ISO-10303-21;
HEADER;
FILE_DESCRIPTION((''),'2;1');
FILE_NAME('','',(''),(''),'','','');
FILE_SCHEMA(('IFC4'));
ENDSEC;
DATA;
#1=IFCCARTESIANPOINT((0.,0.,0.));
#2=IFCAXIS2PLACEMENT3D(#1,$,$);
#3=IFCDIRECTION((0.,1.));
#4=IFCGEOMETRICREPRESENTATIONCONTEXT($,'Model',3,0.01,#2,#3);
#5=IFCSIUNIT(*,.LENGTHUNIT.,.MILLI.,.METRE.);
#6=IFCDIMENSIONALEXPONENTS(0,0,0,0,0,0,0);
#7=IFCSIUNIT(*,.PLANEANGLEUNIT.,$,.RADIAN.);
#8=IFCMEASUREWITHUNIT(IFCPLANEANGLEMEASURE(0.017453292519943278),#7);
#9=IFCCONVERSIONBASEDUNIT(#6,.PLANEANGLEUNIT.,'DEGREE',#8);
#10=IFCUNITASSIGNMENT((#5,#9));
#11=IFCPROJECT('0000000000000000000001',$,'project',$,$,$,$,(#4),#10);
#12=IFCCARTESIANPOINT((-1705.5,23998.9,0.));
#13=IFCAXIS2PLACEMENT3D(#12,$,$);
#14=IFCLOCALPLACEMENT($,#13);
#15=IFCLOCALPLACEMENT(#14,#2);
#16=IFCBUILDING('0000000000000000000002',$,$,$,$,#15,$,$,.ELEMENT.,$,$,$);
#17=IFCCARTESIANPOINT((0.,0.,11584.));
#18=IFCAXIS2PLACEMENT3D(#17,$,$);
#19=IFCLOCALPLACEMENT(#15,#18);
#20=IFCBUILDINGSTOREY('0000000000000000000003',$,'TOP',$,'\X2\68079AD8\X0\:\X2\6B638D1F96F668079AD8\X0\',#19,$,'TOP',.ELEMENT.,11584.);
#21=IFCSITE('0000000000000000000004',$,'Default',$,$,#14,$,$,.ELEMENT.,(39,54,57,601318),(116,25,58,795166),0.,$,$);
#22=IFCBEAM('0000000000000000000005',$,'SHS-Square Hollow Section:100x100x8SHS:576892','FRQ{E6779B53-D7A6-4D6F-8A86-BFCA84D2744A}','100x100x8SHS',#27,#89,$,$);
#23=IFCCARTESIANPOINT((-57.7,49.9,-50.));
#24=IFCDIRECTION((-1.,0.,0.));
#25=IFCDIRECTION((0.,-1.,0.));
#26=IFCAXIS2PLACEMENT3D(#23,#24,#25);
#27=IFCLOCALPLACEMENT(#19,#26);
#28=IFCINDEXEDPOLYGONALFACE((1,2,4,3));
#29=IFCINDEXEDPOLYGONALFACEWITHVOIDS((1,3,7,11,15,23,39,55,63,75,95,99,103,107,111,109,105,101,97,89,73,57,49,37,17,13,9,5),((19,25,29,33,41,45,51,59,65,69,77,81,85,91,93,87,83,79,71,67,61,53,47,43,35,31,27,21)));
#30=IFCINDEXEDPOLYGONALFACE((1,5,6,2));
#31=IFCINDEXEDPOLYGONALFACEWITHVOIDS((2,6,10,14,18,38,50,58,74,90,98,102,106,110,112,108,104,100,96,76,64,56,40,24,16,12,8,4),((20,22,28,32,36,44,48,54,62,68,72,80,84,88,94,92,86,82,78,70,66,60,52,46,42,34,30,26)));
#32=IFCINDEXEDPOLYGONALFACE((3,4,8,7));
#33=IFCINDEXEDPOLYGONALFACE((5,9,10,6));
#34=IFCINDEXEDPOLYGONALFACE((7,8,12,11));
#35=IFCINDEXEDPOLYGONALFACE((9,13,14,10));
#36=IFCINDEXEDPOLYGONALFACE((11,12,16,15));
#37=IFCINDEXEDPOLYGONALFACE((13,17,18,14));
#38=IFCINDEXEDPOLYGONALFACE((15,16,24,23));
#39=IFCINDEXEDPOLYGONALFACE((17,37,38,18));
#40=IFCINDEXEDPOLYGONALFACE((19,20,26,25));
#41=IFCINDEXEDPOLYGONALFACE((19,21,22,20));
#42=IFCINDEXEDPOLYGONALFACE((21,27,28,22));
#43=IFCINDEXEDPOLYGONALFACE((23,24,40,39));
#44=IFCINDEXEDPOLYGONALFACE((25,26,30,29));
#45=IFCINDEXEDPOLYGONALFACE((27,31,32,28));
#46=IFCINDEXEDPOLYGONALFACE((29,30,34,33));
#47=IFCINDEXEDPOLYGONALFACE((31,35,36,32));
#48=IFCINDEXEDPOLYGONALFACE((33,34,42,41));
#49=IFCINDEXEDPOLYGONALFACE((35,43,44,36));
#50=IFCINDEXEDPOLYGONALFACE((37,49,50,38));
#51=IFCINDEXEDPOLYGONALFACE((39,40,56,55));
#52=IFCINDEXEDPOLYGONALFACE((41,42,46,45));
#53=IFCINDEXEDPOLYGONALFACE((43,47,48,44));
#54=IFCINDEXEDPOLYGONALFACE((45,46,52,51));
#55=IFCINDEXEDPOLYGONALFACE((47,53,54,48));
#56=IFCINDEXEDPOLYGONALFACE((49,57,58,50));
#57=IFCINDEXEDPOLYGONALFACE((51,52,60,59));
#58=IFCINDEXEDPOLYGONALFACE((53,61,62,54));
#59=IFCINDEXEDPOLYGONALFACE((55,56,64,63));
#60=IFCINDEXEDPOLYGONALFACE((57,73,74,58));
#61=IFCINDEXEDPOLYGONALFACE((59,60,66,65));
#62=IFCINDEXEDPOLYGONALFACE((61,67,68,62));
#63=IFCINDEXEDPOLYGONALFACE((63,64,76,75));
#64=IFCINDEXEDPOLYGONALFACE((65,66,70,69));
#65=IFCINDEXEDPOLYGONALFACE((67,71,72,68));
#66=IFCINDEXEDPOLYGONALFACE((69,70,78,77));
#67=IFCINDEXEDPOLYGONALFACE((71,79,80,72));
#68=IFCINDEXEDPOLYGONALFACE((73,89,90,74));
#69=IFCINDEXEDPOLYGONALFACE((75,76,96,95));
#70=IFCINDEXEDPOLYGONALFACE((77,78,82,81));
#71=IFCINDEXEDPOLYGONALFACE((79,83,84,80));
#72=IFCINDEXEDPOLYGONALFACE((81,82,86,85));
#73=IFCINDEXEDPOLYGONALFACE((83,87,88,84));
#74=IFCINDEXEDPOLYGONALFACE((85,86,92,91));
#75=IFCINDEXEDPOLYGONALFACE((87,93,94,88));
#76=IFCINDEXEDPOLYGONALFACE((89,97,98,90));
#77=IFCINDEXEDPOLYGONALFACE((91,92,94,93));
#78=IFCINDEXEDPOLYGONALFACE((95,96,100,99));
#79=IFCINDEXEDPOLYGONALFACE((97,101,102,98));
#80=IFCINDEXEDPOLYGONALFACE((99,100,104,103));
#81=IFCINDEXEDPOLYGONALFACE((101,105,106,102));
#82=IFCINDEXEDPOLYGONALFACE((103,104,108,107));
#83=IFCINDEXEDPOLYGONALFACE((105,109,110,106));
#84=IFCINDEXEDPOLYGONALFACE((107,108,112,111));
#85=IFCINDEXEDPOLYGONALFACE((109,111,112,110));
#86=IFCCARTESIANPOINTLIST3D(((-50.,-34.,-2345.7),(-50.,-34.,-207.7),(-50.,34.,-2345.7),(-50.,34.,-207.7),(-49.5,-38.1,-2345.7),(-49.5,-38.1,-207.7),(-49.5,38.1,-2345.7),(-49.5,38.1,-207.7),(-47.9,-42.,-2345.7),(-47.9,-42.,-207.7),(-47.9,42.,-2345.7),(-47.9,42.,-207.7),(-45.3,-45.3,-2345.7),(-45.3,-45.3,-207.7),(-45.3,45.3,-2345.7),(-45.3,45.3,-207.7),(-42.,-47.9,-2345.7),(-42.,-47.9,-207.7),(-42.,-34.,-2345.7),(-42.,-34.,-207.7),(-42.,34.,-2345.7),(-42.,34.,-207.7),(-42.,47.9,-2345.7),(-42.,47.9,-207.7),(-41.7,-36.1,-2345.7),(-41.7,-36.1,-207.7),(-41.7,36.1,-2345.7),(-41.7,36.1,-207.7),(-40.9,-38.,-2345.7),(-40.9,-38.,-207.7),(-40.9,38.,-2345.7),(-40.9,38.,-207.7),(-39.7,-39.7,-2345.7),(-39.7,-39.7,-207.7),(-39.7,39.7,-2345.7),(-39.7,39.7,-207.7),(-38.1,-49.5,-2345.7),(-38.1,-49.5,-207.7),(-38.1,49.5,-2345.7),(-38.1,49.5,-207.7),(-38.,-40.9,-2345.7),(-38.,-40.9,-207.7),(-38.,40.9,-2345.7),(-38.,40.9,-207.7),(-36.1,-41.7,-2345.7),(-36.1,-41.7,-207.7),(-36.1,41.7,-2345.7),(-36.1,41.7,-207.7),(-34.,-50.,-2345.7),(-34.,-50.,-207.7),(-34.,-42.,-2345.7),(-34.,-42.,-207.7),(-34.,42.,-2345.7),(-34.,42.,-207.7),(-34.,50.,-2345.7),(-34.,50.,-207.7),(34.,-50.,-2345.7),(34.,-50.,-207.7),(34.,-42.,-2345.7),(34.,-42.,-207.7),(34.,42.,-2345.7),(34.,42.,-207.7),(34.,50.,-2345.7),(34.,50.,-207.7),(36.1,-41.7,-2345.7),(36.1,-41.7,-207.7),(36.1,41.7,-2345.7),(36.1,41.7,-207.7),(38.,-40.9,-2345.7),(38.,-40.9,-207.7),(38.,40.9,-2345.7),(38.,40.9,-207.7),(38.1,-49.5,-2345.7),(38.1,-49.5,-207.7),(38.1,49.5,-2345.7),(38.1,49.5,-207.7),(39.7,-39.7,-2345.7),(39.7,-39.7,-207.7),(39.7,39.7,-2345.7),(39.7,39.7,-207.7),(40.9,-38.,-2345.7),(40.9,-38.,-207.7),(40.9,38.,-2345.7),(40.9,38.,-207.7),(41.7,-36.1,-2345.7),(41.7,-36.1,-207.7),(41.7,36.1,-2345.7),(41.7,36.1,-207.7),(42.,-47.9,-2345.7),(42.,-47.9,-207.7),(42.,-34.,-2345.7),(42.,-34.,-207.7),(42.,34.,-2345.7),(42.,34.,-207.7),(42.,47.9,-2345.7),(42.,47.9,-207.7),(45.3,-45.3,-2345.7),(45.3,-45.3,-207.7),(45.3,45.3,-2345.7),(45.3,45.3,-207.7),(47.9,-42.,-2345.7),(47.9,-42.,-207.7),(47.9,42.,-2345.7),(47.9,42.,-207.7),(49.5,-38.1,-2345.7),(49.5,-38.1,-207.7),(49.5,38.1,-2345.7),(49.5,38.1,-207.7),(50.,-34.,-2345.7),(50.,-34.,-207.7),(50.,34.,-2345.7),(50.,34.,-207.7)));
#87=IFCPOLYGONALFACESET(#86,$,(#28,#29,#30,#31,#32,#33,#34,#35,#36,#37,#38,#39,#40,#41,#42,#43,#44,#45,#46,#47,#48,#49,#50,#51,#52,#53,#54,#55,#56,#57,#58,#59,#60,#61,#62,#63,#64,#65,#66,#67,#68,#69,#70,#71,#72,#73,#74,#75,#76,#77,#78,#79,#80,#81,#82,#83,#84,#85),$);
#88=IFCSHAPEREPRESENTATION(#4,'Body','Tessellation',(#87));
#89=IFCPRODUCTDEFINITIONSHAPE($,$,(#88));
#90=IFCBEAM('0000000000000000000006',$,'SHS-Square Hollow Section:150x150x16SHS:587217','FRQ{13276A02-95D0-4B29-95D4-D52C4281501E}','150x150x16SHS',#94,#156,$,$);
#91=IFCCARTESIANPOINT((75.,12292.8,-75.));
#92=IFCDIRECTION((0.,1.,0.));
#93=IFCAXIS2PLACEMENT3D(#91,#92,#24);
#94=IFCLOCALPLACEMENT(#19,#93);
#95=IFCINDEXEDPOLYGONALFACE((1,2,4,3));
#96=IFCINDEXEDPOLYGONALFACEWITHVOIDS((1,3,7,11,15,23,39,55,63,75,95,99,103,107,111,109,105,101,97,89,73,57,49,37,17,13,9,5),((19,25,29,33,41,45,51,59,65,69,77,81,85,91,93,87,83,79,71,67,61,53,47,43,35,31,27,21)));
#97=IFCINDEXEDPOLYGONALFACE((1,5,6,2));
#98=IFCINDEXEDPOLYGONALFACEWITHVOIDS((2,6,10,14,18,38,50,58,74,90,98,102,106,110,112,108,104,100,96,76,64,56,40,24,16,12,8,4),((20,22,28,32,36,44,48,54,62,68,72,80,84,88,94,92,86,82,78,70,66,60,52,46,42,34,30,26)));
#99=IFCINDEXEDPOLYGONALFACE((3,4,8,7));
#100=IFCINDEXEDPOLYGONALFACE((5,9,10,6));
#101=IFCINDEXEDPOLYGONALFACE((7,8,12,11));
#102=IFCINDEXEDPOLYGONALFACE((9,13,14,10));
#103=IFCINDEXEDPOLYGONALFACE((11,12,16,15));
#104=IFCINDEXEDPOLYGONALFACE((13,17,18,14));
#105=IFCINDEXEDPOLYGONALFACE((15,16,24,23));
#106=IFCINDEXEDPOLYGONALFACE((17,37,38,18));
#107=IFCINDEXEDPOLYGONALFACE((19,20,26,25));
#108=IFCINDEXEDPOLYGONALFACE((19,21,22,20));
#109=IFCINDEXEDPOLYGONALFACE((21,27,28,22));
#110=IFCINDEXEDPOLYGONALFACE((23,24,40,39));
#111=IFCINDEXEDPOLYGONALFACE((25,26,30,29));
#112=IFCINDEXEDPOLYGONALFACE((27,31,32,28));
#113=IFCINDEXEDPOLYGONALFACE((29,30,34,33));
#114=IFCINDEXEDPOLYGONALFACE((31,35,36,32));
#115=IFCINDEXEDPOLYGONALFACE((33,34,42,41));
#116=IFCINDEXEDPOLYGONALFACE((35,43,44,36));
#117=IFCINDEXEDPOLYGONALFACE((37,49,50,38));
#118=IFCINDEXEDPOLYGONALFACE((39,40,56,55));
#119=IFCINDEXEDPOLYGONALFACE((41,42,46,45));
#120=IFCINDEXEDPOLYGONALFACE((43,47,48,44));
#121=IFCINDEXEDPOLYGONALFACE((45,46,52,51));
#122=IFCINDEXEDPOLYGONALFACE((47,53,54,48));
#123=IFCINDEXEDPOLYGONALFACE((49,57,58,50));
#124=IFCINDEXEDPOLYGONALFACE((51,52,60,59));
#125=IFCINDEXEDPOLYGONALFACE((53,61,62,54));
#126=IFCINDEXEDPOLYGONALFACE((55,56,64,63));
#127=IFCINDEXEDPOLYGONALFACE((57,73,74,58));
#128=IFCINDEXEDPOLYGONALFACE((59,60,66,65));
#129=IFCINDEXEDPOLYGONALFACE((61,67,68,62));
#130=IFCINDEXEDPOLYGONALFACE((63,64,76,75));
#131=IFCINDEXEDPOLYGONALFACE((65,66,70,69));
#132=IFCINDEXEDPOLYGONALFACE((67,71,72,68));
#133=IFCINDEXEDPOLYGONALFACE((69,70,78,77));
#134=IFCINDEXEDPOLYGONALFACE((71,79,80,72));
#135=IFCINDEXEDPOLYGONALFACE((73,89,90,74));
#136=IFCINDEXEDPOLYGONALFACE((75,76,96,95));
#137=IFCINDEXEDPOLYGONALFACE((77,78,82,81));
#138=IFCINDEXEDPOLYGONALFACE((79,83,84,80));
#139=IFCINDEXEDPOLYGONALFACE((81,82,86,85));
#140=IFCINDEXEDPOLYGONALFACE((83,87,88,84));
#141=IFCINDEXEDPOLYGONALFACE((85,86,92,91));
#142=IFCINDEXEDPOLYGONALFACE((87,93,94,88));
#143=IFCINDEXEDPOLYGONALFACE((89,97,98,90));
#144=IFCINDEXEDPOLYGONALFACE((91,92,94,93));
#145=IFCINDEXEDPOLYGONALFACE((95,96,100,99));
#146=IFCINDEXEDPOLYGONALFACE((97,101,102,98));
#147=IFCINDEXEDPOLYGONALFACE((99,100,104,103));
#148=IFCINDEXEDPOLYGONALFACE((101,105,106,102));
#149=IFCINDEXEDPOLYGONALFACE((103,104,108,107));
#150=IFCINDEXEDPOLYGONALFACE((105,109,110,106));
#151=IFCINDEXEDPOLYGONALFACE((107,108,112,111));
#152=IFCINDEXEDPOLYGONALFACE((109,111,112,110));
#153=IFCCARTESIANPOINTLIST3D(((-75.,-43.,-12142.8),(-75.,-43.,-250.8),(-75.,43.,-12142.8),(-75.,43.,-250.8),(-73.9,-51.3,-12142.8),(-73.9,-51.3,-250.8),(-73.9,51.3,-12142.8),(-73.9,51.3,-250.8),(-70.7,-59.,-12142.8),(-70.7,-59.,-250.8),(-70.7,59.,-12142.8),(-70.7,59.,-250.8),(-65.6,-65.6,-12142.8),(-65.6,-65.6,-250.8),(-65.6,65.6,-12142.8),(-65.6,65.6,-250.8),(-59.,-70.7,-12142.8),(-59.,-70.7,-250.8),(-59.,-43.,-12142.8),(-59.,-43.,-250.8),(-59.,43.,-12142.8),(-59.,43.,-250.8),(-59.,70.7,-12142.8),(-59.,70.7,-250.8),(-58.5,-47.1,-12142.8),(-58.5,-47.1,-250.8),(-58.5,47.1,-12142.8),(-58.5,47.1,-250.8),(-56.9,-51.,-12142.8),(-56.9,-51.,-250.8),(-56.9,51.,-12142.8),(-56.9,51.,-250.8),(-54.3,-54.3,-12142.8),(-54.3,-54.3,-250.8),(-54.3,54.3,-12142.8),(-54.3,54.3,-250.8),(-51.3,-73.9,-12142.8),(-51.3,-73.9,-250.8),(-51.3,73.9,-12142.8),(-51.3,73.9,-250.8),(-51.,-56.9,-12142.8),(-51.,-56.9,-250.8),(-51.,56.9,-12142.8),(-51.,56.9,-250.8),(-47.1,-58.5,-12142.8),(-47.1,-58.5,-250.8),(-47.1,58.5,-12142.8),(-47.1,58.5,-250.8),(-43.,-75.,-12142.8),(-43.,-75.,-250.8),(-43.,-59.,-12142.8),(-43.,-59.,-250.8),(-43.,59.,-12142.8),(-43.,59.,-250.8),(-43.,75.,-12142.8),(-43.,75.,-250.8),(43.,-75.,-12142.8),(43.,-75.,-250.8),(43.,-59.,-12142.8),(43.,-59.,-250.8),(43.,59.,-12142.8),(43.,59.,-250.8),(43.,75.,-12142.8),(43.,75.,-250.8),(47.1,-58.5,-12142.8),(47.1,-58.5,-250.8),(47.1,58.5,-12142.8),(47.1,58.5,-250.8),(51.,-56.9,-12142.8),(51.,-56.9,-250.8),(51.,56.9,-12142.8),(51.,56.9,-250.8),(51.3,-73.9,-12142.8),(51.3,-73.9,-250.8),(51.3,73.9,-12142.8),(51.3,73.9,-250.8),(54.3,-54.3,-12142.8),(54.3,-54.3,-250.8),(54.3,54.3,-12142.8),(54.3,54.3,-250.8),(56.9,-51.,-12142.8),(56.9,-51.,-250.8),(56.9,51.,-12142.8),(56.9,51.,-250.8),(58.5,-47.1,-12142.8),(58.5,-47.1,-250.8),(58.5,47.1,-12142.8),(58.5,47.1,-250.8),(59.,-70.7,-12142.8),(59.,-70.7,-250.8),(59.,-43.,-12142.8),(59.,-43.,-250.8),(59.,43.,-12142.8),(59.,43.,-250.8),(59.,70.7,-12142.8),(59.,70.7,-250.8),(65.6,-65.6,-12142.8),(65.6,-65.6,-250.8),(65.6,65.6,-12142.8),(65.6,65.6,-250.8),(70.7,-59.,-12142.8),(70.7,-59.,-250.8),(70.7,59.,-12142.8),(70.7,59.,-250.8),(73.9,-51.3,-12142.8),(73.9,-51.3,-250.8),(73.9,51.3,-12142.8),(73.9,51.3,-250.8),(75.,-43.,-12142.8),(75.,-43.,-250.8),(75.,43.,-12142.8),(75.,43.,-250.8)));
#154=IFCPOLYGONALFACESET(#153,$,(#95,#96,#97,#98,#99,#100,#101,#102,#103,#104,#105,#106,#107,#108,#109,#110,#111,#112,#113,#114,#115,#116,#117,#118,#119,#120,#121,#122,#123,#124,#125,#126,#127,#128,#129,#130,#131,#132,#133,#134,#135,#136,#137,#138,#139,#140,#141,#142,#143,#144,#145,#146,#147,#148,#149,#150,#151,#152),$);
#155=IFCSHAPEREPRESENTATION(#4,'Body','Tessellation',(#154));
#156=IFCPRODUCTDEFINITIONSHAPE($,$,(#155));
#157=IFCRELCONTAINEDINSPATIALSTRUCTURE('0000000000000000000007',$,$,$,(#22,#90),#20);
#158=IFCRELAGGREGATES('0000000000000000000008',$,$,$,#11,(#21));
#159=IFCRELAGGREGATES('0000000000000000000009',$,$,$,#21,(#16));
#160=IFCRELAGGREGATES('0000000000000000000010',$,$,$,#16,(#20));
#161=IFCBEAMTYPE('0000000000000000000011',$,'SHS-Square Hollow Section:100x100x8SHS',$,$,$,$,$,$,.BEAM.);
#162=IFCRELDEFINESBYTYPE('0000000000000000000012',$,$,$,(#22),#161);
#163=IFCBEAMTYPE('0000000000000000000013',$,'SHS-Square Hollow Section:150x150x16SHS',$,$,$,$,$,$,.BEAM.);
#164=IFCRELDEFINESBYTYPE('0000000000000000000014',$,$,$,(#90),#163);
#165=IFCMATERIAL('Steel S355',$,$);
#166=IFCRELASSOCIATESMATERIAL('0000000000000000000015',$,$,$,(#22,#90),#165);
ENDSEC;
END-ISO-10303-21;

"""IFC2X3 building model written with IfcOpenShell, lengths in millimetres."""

from ifc_helpers import new_model, entity, si_unit, converted_unit, direction, frame, origin, origin_2d, place, context, project, spatial, hollow_rectangle, extrude, clip, halfspace, material, type_object, element, save


model = new_model("IFC2X3")

# Units and contexts
model_context = context("Model", 3, precision=0.01, world=origin(), true_north=direction((0.0, 1.0)))
ifc_project = project(units=[si_unit("LENGTHUNIT", "METRE", prefix="MILLI"), converted_unit("PLANEANGLEUNIT", "DEGREE", entity("IfcPlaneAngleMeasure", 0.017453292519943278), si_unit("PLANEANGLEUNIT", "RADIAN"), dimensions=[0, 0, 0, 0, 0, 0, 0])], contexts=[model_context])

# Site, building, storey
site_placement = place(None, frame((-1705.5, 23998.9, 0.0)))
site = spatial("IfcSite", under=ifc_project, at=site_placement, Name="Default", CompositionType="ELEMENT", RefLatitude=(39, 54, 57, 601318), RefLongitude=(116, 25, 58, 795166), RefElevation=0.0)
building_placement = place(site_placement, origin())
building = spatial("IfcBuilding", under=site, at=building_placement, CompositionType="ELEMENT")
storey_placement = place(building_placement, frame((0.0, 0.0, 11584.0)))
storey = spatial("IfcBuildingStorey", under=building, at=storey_placement, Name="TOP", ObjectType="标高:正负零标高", LongName="TOP", CompositionType="ELEMENT", Elevation=11584.0)

# Shared definitions
ifc_material_1 = material(Name="Steel S355")

# Beams
beam_type_1 = type_object("IfcBeamType", Name="SHS-Square Hollow Section:100x100x8SHS", PredefinedType="BEAM")
beam_1_placement = place(storey_placement, frame((-57.7, 49.9, -50.0), z_axis=(-1.0, 0.0, 0.0), x_axis=(0.0, -1.0, 0.0)))
element("IfcBeam", 1, at=beam_1_placement, inside=storey, type_object=beam_type_1, material=ifc_material_1, Name="SHS-Square Hollow Section:100x100x8SHS:576892", Description="FRQ{E6779B53-D7A6-4D6F-8A86-BFCA84D2744A}", ObjectType="100x100x8SHS", context=model_context, shape_type="Clipping", body=[
    clip(clip(extrude(hollow_rectangle(XDim=100.0, YDim=100.0, WallThickness=8.0, InnerFilletRadius=8.0, OuterFilletRadius=16.0, at=origin_2d()), origin(), (0.0, 0.0, -1.0), 2551.4), halfspace(frame((49.9, -11534.0, -207.7), z_axis=(0.0, 0.0, -1.0), x_axis=(-1.0, 0.0, 0.0)), True)), halfspace(frame((49.9, -11534.0, -2345.7), z_axis=(0.0, 0.0, 1.0), x_axis=(1.0, 0.0, 0.0)), True)),
])
beam_type_2 = type_object("IfcBeamType", Name="SHS-Square Hollow Section:150x150x16SHS", PredefinedType="BEAM")
beam_2_placement = place(storey_placement, frame((75.0, 12292.8, -75.0), z_axis=(0.0, 1.0, 0.0), x_axis=(-1.0, 0.0, 0.0)))
element("IfcBeam", 2, at=beam_2_placement, inside=storey, type_object=beam_type_2, material=ifc_material_1, Name="SHS-Square Hollow Section:150x150x16SHS:587217", Description="FRQ{13276A02-95D0-4B29-95D4-D52C4281501E}", ObjectType="150x150x16SHS", context=model_context, shape_type="Clipping", body=[
    clip(clip(extrude(hollow_rectangle(XDim=150.0, YDim=150.0, WallThickness=16.0, InnerFilletRadius=16.0, OuterFilletRadius=32.0, at=origin_2d()), origin(), (0.0, 0.0, -1.0), 12398.9), halfspace(frame((75.0, -11509.0, -12142.8), z_axis=(0.0, 0.0, 1.0), x_axis=(1.0, 0.0, 0.0)), True)), halfspace(frame((75.0, -11509.0, -250.8), z_axis=(0.0, 0.0, -1.0), x_axis=(-1.0, 0.0, 0.0)), True)),
])

save(model, "model.ifc")
